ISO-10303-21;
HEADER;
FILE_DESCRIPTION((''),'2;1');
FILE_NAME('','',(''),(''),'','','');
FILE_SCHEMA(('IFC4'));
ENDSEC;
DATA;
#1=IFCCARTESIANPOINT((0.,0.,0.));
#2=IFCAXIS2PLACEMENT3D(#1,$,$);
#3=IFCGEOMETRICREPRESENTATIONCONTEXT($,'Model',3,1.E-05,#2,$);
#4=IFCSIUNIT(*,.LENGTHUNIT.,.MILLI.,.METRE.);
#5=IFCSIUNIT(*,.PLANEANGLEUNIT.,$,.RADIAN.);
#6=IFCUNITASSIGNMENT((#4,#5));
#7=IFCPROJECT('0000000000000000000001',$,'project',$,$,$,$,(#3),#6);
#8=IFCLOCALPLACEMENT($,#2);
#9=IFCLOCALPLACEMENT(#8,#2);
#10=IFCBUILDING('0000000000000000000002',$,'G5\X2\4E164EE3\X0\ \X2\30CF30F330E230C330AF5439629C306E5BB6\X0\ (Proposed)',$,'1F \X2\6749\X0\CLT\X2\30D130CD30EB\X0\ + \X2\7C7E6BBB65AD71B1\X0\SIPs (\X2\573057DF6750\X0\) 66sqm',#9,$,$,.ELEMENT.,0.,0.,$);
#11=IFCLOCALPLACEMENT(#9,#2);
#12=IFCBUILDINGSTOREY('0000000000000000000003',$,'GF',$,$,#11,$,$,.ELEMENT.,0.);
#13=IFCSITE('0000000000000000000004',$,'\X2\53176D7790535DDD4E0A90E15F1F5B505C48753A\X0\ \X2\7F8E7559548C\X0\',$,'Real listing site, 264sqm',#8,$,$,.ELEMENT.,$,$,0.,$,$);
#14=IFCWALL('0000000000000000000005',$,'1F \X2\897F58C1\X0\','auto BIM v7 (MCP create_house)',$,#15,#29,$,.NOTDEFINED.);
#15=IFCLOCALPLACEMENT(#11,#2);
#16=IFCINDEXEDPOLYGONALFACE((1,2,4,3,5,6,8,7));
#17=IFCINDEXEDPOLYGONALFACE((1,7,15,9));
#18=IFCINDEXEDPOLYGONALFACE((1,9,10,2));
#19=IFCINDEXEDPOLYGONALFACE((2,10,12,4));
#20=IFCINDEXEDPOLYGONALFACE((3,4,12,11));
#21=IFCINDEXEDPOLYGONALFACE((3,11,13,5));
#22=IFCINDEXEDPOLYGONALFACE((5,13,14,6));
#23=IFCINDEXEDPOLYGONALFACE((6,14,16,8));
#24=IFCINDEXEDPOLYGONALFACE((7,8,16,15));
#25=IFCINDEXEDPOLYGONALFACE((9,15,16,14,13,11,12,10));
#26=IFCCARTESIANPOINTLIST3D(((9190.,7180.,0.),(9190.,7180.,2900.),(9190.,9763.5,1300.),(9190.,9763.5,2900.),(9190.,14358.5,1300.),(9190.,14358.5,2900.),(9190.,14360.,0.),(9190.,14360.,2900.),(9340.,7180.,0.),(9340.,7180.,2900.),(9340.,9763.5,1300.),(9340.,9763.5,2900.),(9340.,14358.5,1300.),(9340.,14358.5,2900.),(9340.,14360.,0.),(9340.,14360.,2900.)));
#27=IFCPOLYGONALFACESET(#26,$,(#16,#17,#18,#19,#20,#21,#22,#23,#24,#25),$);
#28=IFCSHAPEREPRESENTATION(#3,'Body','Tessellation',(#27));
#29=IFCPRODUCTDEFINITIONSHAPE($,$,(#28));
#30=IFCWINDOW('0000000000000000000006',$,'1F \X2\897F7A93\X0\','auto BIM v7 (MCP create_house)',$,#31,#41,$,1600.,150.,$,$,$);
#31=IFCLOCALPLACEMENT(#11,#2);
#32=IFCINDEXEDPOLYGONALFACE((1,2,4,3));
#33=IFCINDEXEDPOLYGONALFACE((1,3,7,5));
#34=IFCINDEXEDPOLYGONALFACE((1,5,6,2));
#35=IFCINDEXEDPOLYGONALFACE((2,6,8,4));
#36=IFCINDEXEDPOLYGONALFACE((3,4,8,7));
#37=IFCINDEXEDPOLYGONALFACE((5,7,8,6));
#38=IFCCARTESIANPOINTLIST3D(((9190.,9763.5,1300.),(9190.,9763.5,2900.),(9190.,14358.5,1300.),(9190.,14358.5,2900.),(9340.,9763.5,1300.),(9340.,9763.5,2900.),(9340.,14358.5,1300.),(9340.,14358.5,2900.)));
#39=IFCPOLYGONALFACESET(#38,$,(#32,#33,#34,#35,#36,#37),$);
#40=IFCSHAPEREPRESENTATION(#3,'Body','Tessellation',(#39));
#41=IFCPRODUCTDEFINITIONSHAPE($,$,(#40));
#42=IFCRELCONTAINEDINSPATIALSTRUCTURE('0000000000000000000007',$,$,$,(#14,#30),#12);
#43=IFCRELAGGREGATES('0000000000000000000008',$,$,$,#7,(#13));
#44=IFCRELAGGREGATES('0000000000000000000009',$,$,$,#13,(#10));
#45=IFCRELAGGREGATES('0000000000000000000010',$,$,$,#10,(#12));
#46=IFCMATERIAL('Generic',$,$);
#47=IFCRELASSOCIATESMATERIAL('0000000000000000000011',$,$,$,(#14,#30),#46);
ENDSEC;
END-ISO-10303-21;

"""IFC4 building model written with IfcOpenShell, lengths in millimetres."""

from ifc_helpers import new_model, si_unit, frame, frame_2d, origin, place, context, project, spatial, rectangle, extrude, material, element, fill, save


model = new_model("IFC4")

# Units and contexts
model_context = context("Model", 3, precision=1e-05, world=origin())
ifc_project = project(units=[si_unit("LENGTHUNIT", "METRE", prefix="MILLI"), si_unit("PLANEANGLEUNIT", "RADIAN")], contexts=[model_context])

# Site, building, storey
site_placement = place(None, origin())
site = spatial("IfcSite", under=ifc_project, at=site_placement, Name="北海道川上郡弟子屈町 美留和", ObjectType="Real listing site, 264sqm", CompositionType="ELEMENT", RefElevation=0.0)
building_placement = place(site_placement, origin())
building = spatial("IfcBuilding", under=site, at=building_placement, Name="G5世代 ハンモック吹抜の家 (Proposed)", ObjectType="1F 杉CLTパネル + 籾殻断熱SIPs (地域材) 66sqm", CompositionType="ELEMENT", ElevationOfRefHeight=0.0, ElevationOfTerrain=0.0)
storey_placement = place(building_placement, origin())
storey = spatial("IfcBuildingStorey", under=building, at=storey_placement, Name="GF", CompositionType="ELEMENT", Elevation=0.0)

# Shared definitions
ifc_material = material(Name="Generic")

# Wall, opening, window
wall_1_placement = place(storey_placement, frame((4595.0, 3590.0, 0.0)))
wall_1 = element("IfcWall", 1, at=wall_1_placement, inside=storey, material=ifc_material, Name="1F 西壁", Description="auto BIM v7 (MCP create_house)", PredefinedType="NOTDEFINED", context=model_context, shape_type="SweptSolid", body=[
    extrude(rectangle(XDim=150.0, YDim=7180.0, at=frame_2d((75.0, 3590.0))), frame((4595.0, 3590.0, 0.0)), (0.0, 0.0, 1.0), 2900.0),
])
opening_1_placement = place(storey_placement, frame((4595.0, 4882.0, 650.0)))
opening_1 = element("IfcOpeningElement", 2, at=opening_1_placement, cuts=wall_1, PredefinedType="NOTDEFINED", context=model_context, shape_type="SweptSolid", body=[
    extrude(rectangle(XDim=150.0, YDim=4595.0, at=frame_2d((75.0, 2297.0))), frame((4595.0, 4882.0, 650.0)), (0.0, 0.0, 1.0), 1600.0),
])
window_1_placement = place(storey_placement, frame((4595.0, 4882.0, 650.0)))
window_1 = element("IfcWindow", 3, at=window_1_placement, inside=storey, material=ifc_material, Name="1F 西窓", Description="auto BIM v7 (MCP create_house)", OverallHeight=1600.0, OverallWidth=150.0, context=model_context, shape_type="SweptSolid", body=[
    extrude(rectangle(XDim=150.0, YDim=4595.0, at=frame_2d((75.0, 2297.0))), frame((4595.0, 4882.0, 650.0)), (0.0, 0.0, 1.0), 1600.0),
])
fill(opening_1, window_1)

save(model, "model.ifc")
